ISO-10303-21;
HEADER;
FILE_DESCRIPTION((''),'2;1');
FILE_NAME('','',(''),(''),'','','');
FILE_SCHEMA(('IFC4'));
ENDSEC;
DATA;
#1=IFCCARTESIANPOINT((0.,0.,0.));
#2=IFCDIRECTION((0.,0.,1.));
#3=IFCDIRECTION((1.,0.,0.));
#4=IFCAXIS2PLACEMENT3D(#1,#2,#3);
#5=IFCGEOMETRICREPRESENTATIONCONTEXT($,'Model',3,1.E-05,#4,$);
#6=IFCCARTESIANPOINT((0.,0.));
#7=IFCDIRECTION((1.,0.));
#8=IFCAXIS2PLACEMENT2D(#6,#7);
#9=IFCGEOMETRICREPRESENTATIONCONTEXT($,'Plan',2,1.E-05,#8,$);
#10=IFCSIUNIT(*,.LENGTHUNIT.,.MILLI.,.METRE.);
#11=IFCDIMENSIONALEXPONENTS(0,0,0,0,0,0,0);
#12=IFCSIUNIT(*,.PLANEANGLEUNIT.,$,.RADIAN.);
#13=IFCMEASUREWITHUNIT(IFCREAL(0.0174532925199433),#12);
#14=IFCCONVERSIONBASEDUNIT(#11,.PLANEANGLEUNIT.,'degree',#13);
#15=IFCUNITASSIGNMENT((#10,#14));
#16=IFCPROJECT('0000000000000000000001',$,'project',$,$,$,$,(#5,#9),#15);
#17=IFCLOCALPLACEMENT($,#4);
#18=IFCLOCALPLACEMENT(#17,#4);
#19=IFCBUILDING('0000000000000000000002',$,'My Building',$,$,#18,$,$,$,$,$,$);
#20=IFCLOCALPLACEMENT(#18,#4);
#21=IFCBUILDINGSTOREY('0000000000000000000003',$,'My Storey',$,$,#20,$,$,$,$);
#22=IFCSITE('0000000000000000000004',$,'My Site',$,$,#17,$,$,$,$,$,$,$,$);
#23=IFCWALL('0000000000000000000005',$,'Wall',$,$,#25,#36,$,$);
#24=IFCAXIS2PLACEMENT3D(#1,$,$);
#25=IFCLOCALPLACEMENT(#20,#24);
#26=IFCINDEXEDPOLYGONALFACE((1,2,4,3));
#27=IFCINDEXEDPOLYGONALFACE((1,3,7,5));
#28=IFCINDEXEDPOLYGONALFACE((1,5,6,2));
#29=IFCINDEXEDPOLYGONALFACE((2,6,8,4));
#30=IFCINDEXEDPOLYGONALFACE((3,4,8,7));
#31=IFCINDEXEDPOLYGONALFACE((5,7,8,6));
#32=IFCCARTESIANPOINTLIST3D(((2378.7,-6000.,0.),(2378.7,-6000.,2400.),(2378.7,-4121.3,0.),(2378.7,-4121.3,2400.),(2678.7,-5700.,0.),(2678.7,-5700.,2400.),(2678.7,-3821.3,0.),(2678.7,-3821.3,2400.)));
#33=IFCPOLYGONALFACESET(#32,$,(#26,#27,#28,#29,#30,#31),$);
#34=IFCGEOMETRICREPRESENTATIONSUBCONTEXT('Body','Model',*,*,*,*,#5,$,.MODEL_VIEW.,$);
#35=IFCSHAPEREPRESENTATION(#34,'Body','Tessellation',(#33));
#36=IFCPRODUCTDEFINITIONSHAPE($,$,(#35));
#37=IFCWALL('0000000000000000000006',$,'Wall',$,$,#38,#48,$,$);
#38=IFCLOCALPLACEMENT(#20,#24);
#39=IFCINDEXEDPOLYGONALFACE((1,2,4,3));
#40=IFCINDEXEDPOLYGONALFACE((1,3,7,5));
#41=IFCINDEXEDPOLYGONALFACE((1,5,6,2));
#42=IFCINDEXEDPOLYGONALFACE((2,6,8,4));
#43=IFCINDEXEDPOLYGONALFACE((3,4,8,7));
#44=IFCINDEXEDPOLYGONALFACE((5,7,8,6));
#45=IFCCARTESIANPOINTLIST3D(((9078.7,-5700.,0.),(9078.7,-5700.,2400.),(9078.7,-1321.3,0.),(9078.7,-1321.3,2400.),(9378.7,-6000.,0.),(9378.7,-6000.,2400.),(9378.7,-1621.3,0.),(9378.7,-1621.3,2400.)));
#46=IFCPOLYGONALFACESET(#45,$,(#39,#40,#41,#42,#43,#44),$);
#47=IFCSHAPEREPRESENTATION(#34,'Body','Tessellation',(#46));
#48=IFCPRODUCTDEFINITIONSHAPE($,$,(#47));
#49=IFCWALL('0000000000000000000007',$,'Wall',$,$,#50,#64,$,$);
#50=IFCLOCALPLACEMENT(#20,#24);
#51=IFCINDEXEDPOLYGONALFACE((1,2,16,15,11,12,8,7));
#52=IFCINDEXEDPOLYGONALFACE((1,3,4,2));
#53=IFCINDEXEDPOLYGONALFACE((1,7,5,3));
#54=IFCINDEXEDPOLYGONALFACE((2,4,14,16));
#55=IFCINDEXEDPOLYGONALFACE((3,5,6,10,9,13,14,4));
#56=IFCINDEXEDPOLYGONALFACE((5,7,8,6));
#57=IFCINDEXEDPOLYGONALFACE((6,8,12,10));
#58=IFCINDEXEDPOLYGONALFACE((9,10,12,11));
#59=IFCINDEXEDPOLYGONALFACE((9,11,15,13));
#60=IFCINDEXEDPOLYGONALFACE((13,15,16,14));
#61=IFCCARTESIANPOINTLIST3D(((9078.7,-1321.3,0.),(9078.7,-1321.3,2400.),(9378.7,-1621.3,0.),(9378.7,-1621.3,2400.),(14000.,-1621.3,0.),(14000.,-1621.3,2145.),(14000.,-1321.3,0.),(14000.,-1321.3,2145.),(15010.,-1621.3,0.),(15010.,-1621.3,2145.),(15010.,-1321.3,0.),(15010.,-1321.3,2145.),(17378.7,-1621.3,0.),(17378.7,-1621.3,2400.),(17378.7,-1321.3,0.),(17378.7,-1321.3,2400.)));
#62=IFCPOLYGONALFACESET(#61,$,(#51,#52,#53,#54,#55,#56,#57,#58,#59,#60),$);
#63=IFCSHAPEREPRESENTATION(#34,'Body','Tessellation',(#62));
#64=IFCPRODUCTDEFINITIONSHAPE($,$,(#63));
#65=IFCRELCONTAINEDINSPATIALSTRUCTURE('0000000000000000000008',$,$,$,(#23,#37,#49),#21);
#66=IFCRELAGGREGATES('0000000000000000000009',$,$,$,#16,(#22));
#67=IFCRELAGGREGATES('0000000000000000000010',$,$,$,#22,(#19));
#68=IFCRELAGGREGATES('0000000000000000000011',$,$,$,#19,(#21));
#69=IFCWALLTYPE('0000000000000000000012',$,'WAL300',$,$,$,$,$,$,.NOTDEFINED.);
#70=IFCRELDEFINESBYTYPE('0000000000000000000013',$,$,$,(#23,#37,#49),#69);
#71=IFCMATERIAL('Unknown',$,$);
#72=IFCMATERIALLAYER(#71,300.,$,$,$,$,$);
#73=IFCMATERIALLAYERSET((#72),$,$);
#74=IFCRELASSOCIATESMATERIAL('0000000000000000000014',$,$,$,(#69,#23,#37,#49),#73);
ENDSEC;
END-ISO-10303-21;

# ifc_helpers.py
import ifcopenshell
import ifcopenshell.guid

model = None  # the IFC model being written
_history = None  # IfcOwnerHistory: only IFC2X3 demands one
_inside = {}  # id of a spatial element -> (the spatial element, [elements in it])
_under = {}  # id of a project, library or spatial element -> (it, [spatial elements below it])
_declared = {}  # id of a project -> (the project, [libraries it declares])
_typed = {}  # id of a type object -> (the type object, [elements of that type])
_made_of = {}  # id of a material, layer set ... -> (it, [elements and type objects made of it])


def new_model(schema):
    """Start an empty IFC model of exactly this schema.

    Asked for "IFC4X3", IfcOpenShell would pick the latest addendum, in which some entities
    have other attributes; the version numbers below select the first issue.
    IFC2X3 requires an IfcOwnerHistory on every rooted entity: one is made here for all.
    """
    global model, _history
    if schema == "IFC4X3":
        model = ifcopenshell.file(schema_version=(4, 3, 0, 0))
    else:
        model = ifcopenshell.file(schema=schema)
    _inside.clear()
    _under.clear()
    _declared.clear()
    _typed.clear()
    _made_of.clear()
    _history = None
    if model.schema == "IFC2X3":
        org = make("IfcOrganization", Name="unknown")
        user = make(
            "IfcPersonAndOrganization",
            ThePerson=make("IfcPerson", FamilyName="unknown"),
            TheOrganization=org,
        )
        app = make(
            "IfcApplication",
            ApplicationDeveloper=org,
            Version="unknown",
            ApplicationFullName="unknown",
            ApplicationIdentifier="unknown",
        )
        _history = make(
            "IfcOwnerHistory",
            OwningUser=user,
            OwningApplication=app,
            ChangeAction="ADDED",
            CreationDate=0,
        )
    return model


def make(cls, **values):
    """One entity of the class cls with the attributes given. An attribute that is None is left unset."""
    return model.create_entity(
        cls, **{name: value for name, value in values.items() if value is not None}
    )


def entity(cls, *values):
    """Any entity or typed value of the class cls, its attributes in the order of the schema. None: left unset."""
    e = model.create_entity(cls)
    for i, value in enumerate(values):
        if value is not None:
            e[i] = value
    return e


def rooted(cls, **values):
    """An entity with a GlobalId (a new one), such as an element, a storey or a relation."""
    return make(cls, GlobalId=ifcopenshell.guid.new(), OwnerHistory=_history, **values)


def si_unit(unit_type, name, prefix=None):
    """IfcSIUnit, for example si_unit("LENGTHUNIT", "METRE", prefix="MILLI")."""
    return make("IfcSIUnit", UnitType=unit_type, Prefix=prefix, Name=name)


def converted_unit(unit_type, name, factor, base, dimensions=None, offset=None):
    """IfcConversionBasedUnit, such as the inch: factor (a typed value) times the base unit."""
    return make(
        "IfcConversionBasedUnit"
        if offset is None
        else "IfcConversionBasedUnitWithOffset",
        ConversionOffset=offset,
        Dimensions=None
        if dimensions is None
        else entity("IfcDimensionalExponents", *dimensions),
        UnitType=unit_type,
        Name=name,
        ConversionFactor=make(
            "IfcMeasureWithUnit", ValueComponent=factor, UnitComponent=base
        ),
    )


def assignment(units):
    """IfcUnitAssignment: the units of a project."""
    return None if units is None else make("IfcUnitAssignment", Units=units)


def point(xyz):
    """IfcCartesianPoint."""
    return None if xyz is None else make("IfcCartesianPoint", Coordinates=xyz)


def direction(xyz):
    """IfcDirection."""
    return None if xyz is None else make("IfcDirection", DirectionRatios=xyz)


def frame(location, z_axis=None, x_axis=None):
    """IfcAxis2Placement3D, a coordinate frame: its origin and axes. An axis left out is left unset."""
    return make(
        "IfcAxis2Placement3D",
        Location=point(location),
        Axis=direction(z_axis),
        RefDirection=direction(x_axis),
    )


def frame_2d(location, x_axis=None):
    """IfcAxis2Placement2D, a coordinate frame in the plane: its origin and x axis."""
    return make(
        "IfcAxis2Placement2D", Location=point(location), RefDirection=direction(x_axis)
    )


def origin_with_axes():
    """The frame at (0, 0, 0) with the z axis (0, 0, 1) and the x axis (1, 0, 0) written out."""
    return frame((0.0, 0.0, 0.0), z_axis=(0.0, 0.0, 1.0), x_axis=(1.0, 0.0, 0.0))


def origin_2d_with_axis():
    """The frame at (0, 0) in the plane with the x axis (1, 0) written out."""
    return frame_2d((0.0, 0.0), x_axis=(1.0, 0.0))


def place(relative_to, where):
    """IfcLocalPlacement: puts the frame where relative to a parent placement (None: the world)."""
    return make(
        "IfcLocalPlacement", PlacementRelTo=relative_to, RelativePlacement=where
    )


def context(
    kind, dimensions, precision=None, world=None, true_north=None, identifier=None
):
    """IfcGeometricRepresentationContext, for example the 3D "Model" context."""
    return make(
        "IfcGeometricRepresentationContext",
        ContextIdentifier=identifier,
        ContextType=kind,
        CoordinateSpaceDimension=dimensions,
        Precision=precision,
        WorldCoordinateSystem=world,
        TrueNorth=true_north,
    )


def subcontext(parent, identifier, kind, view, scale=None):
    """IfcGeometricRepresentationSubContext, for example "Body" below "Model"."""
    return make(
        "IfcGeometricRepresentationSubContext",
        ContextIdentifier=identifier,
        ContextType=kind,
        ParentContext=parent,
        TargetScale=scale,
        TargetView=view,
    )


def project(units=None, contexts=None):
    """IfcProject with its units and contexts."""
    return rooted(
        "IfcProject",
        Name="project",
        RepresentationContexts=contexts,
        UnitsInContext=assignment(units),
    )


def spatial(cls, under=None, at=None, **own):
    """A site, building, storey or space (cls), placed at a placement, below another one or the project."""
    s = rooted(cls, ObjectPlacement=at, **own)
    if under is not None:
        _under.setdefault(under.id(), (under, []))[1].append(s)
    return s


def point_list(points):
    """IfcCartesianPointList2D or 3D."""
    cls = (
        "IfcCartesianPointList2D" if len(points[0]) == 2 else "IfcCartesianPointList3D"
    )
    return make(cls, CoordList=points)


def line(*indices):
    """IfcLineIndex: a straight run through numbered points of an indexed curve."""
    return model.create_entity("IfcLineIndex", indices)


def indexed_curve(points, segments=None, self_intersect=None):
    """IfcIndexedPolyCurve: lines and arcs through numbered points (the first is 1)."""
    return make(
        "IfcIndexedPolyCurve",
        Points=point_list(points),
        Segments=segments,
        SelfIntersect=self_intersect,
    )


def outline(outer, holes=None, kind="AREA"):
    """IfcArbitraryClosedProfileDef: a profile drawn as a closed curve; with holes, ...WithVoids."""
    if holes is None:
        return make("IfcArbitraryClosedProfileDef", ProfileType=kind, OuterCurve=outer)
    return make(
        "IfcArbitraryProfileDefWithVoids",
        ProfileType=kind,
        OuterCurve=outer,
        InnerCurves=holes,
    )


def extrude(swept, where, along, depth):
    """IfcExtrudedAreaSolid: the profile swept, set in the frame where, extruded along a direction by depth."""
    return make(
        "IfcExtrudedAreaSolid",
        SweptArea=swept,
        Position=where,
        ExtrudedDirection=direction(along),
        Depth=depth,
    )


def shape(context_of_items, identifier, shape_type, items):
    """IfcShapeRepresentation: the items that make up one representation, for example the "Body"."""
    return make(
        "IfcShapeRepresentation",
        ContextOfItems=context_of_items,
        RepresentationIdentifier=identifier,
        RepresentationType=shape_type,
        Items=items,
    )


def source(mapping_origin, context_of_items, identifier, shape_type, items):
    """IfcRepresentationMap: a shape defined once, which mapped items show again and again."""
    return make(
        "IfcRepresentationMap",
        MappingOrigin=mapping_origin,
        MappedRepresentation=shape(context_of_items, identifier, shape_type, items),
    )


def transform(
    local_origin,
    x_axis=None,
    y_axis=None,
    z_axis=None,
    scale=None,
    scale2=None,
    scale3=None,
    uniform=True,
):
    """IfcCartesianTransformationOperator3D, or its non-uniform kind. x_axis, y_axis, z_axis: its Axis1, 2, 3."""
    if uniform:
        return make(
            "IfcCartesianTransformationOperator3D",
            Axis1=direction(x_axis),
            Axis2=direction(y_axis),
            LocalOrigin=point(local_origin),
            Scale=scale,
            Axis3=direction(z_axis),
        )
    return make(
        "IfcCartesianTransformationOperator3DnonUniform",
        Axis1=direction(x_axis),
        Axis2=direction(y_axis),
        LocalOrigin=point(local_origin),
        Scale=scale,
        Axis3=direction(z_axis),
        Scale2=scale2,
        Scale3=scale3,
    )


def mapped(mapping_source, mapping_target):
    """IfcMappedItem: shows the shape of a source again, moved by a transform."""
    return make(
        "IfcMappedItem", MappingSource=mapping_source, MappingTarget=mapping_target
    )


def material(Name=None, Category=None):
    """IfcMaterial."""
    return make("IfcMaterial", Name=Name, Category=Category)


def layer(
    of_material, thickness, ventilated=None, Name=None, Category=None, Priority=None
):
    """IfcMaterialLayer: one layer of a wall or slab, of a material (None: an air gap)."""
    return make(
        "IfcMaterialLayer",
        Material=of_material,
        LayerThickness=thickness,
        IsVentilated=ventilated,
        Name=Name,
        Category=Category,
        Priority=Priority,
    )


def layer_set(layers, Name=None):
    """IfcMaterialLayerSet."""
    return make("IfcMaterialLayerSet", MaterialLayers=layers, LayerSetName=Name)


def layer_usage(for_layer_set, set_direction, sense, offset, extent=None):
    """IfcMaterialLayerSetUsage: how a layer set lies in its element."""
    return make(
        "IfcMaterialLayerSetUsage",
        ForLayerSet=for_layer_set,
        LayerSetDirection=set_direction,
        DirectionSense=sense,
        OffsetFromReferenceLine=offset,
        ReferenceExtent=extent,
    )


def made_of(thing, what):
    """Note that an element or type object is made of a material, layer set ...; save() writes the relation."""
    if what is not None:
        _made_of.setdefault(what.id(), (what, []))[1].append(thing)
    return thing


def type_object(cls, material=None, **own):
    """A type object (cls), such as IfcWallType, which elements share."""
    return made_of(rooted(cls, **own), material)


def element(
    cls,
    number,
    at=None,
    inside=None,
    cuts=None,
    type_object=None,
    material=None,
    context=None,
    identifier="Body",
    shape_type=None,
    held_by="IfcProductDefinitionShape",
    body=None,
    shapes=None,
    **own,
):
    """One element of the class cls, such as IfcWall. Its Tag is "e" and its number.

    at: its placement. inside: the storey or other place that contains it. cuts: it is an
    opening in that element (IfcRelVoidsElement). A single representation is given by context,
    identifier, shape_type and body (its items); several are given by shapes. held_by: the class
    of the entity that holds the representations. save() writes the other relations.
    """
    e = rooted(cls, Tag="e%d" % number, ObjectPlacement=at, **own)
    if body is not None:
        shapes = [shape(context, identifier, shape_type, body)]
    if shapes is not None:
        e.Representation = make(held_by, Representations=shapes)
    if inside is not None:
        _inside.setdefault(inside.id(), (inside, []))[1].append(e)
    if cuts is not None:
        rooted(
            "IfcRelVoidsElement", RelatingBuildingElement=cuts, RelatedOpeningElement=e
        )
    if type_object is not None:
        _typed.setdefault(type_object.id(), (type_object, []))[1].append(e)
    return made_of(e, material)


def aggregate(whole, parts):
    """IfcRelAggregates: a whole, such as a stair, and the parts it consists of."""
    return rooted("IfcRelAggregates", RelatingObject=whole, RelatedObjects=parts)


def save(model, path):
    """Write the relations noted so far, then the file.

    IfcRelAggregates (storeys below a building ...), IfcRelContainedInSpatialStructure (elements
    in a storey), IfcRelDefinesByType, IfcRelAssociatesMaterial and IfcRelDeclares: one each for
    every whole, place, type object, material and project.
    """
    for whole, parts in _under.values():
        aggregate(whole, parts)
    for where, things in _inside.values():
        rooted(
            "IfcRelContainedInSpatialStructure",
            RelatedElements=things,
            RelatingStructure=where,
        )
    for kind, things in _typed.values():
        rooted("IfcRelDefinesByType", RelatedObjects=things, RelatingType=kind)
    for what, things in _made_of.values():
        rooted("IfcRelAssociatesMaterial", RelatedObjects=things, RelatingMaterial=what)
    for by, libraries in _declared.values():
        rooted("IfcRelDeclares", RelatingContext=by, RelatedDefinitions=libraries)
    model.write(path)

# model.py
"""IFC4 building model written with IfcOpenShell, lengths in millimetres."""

from ifc_helpers import new_model, entity, si_unit, converted_unit, frame, origin_with_axes, origin_2d_with_axis, place, context, subcontext, project, spatial, line, indexed_curve, outline, extrude, source, transform, mapped, material, layer, layer_set, layer_usage, type_object, element, save


model = new_model("IFC4")

# Units and contexts
model_context = context("Model", 3, precision=1e-05, world=origin_with_axes())
plan_context = context("Plan", 2, precision=1e-05, world=origin_2d_with_axis())
body_context_1 = subcontext(model_context, "Body", "Model", "MODEL_VIEW")
ifc_project = project(units=[si_unit("LENGTHUNIT", "METRE", prefix="MILLI"), converted_unit("PLANEANGLEUNIT", "degree", entity("IfcReal", 0.0174532925199433), si_unit("PLANEANGLEUNIT", "RADIAN"), dimensions=[0, 0, 0, 0, 0, 0, 0])], contexts=[model_context, plan_context])

# Site, building, storey
site_placement = place(None, origin_with_axes())
site = spatial("IfcSite", under=ifc_project, at=site_placement, Name="My Site")
building_placement = place(site_placement, origin_with_axes())
building = spatial("IfcBuilding", under=site, at=building_placement, Name="My Building")
storey_placement = place(building_placement, origin_with_axes())
storey = spatial("IfcBuildingStorey", under=building, at=storey_placement, Name="My Storey")

# Shared definitions
ifc_material = material(Name="Unknown")

# Shared definitions
ifc_layer_1 = layer(ifc_material, 300.0)
ifc_layer_set_1 = layer_set([ifc_layer_1])
wall_type = type_object("IfcWallType", Name="WAL300", PredefinedType="NOTDEFINED", material=ifc_layer_set_1)

# Wall
ifc_layer_usage_1 = layer_usage(ifc_layer_set_1, "AXIS2", "POSITIVE", 0.0)
wall_1_placement = place(storey_placement, frame((2378.7, -4121.3, 0.0), z_axis=(0.0, 0.0, 1.0), x_axis=(0.0, -1.0, 0.0)))
element("IfcWall", 1, at=wall_1_placement, inside=storey, type_object=wall_type, material=ifc_layer_usage_1, Name="Wall", context=body_context_1, shape_type="SweptSolid", body=[
    extrude(outline(indexed_curve([(0.0, 0.0), (-300.0, 300.0), (1578.7, 300.0), (1878.7, 0.0)], segments=[line(1, 2, 3, 4, 1)])), origin_with_axes(), (0.0, 0.0, 1.0), 2400.0),
])

# Shared definitions
shared_shape_1 = source(origin_with_axes(), body_context_1, "Body", "SweptSolid", [
    extrude(outline(indexed_curve([(0.0, 0.0), (1010.0, 0.0), (1010.0, 2145.0), (0.0, 2145.0)], segments=[line(1, 2, 3, 4, 1)])), frame((0.0, -600.0, 0.0), z_axis=(0.0, -1.0, 0.0), x_axis=(1.0, 0.0, 0.0)), (0.0, 0.0, -1.0), 1200.0),
])

# Wall
ifc_layer_usage_2 = layer_usage(ifc_layer_set_1, "AXIS2", "POSITIVE", 0.0)
wall_2_placement = place(storey_placement, frame((9378.7, -6000.0, 0.0), z_axis=(0.0, 0.0, 1.0), x_axis=(0.0, 1.0, 0.0)))
element("IfcWall", 2, at=wall_2_placement, inside=storey, type_object=wall_type, material=ifc_layer_usage_2, Name="Wall", context=body_context_1, shape_type="SweptSolid", body=[
    extrude(outline(indexed_curve([(0.0, 0.0), (300.0, 300.0), (4678.7, 300.0), (4378.7, 0.0)], segments=[line(1, 2, 3, 4, 1)])), origin_with_axes(), (0.0, 0.0, 1.0), 2400.0),
])

# Wall, opening
ifc_layer_usage_3 = layer_usage(ifc_layer_set_1, "AXIS2", "POSITIVE", 0.0)
wall_3_placement = place(storey_placement, frame((9378.7, -1621.3, 0.0), z_axis=(0.0, 0.0, 1.0), x_axis=(1.0, 0.0, 0.0)))
wall_3 = element("IfcWall", 3, at=wall_3_placement, inside=storey, type_object=wall_type, material=ifc_layer_usage_3, Name="Wall", context=body_context_1, shape_type="SweptSolid", body=[
    extrude(outline(indexed_curve([(0.0, 0.0), (-300.0, 300.0), (8000.0, 300.0), (8000.0, 0.0)], segments=[line(1, 2, 3, 4, 1)])), origin_with_axes(), (0.0, 0.0, 1.0), 2400.0),
])
opening_1_placement = place(wall_3_placement, frame((4621.3, 0.0, 0.0), z_axis=(0.0, 0.0, 1.0), x_axis=(1.0, 0.0, 0.0)))
element("IfcOpeningElement", 4, at=opening_1_placement, cuts=wall_3, PredefinedType="OPENING", context=body_context_1, shape_type="MappedRepresentation", body=[
    mapped(shared_shape_1, transform((0.0, 0.0, 0.0), x_axis=(1.0, 0.0, 0.0), y_axis=(0.0, 1.0, 0.0), z_axis=(0.0, 0.0, 1.0), scale=1.0)),
])

save(model, "model.ifc")
